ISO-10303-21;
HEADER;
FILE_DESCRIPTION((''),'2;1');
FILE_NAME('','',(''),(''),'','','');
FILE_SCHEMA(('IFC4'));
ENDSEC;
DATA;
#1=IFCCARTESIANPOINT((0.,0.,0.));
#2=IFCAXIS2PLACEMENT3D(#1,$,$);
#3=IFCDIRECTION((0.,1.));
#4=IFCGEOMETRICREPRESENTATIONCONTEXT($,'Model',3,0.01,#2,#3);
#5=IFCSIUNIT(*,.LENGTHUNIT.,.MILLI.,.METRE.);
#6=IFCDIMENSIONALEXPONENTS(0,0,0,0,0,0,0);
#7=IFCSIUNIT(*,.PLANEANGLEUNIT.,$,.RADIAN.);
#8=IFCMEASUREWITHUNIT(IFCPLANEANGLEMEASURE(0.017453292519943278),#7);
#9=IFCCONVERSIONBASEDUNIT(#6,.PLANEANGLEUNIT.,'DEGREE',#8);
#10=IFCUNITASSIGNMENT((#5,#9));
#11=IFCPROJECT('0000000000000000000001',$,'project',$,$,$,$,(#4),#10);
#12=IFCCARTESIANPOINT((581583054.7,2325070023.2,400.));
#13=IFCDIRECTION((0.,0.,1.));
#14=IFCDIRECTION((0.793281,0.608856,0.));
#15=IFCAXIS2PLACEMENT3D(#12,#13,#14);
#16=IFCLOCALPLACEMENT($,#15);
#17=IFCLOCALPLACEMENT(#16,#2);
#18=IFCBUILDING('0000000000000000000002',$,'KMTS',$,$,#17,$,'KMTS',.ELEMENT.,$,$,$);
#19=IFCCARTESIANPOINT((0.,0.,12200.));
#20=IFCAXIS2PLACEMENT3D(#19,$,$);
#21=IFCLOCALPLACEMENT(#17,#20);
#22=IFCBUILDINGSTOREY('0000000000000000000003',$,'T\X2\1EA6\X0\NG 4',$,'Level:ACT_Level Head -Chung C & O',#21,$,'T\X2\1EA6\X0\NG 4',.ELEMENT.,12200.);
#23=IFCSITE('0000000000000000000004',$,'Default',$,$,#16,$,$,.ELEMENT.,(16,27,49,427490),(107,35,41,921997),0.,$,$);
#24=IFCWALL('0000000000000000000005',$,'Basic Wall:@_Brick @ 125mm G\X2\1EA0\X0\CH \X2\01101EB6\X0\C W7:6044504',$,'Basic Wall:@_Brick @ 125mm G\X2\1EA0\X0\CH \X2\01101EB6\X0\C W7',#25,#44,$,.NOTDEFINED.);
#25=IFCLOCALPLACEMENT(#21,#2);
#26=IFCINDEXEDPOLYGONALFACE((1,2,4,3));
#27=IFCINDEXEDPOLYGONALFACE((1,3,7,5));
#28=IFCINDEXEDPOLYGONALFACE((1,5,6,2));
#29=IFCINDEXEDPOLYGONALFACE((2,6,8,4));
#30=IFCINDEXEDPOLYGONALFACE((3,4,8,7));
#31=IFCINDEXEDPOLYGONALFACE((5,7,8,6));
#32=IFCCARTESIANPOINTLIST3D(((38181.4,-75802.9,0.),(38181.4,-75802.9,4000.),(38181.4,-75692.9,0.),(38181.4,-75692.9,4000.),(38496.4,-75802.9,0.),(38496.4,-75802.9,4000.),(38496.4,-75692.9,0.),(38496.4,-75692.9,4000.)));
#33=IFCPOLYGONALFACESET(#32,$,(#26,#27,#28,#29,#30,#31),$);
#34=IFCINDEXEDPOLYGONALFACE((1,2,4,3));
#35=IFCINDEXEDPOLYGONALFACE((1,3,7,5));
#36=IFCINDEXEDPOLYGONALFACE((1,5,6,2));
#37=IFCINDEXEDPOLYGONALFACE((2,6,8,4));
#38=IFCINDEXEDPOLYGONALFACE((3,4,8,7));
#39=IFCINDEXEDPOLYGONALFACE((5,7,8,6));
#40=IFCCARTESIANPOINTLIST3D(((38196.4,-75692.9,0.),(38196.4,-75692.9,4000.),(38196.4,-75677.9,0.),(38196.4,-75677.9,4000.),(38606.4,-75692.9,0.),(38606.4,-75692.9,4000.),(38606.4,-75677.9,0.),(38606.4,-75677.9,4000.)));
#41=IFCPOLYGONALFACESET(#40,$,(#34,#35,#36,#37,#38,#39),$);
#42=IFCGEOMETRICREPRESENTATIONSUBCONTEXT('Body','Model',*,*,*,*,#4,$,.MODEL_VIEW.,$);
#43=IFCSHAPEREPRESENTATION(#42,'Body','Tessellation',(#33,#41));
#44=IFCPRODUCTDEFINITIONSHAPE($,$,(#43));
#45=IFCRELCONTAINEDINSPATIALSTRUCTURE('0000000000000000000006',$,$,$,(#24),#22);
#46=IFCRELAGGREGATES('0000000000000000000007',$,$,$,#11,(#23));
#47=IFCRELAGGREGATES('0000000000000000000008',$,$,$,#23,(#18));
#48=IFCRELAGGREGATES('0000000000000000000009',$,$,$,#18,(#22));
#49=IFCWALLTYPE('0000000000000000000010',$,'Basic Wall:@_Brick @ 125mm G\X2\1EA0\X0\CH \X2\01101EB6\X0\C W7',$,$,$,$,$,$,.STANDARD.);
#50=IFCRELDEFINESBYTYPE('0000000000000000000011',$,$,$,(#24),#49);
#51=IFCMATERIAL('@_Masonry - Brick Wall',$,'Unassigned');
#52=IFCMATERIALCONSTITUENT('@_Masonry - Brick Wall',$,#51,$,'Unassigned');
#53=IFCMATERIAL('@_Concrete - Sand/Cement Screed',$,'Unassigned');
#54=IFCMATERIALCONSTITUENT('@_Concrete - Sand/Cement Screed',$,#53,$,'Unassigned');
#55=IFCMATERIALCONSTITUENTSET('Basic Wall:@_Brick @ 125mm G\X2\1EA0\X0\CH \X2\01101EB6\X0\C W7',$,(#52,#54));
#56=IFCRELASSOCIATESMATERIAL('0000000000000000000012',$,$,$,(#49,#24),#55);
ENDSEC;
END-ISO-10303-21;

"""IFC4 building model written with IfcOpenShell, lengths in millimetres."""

from ifc_helpers import new_model, entity, si_unit, converted_unit, direction, frame, origin, place, context, subcontext, project, spatial, indexed_curve, outline, extrude, material, constituent, constituent_set, type_object, element, save


model = new_model("IFC4")

# Units and contexts
model_context = context("Model", 3, precision=0.01, world=origin(), true_north=direction((0.0, 1.0)))
body_context = subcontext(model_context, "Body", "Model", "MODEL_VIEW")
ifc_project = project(units=[si_unit("LENGTHUNIT", "METRE", prefix="MILLI"), converted_unit("PLANEANGLEUNIT", "DEGREE", entity("IfcPlaneAngleMeasure", 0.017453292519943278), si_unit("PLANEANGLEUNIT", "RADIAN"), dimensions=[0, 0, 0, 0, 0, 0, 0])], contexts=[model_context])

# Site, building, storey
site_placement = place(None, frame((581583054.7, 2325070023.2, 400.0), z_axis=(0.0, 0.0, 1.0), x_axis=(0.793281, 0.608856, 0.0)))
site = spatial("IfcSite", under=ifc_project, at=site_placement, Name="Default", CompositionType="ELEMENT", RefLatitude=(16, 27, 49, 427490), RefLongitude=(107, 35, 41, 921997), RefElevation=0.0)
building_placement = place(site_placement, origin())
building = spatial("IfcBuilding", under=site, at=building_placement, Name="KMTS", LongName="KMTS", CompositionType="ELEMENT")
storey_placement = place(building_placement, frame((0.0, 0.0, 12200.0)))
storey = spatial("IfcBuildingStorey", under=building, at=storey_placement, Name="TẦNG 4", ObjectType="Level:ACT_Level Head -Chung C & O", LongName="TẦNG 4", CompositionType="ELEMENT", Elevation=12200.0)

# Wall
ifc_material_1 = material(Name="@_Masonry - Brick Wall", Category="Unassigned")
ifc_constituent_1 = constituent(ifc_material_1, Name="@_Masonry - Brick Wall", Category="Unassigned")
ifc_material_2 = material(Name="@_Concrete - Sand/Cement Screed", Category="Unassigned")
ifc_constituent_2 = constituent(ifc_material_2, Name="@_Concrete - Sand/Cement Screed", Category="Unassigned")
ifc_constituent_set_1 = constituent_set(constituents=[ifc_constituent_1, ifc_constituent_2], Name="Basic Wall:@_Brick @ 125mm GẠCH ĐẶC W7")
wall_type_1 = type_object("IfcWallType", Name="Basic Wall:@_Brick @ 125mm GẠCH ĐẶC W7", PredefinedType="STANDARD", material=ifc_constituent_set_1)
wall_1_placement = place(storey_placement, frame((38496.4, -75740.4, 0.0), z_axis=(0.0, 0.0, 1.0), x_axis=(-1.0, 0.0, 0.0)))
element("IfcWall", 1, at=wall_1_placement, inside=storey, type_object=wall_type_1, material=ifc_constituent_set_1, Name="Basic Wall:@_Brick @ 125mm GẠCH ĐẶC W7:6044504", ObjectType="Basic Wall:@_Brick @ 125mm GẠCH ĐẶC W7", PredefinedType="NOTDEFINED", context=body_context, shape_type="SweptSolid", body=[
    extrude(outline(indexed_curve([(-55.0, -157.5), (55.0, -157.5), (55.0, 157.5), (-55.0, 157.5), (-55.0, -157.5)], self_intersect=False)), frame((157.5, 7.5, 0.0), z_axis=(0.0, 0.0, 1.0), x_axis=(0.0, -1.0, 0.0)), (0.0, 0.0, 1.0), 4000.0),
    extrude(outline(indexed_curve([(-7.5, -205.0), (7.5, -205.0), (7.5, 205.0), (-7.5, 205.0), (-7.5, -205.0)], self_intersect=False)), frame((95.0, -55.0, 0.0), z_axis=(0.0, 0.0, 1.0), x_axis=(0.0, 1.0, 0.0)), (0.0, 0.0, 1.0), 4000.0),
])

save(model, "model.ifc")
